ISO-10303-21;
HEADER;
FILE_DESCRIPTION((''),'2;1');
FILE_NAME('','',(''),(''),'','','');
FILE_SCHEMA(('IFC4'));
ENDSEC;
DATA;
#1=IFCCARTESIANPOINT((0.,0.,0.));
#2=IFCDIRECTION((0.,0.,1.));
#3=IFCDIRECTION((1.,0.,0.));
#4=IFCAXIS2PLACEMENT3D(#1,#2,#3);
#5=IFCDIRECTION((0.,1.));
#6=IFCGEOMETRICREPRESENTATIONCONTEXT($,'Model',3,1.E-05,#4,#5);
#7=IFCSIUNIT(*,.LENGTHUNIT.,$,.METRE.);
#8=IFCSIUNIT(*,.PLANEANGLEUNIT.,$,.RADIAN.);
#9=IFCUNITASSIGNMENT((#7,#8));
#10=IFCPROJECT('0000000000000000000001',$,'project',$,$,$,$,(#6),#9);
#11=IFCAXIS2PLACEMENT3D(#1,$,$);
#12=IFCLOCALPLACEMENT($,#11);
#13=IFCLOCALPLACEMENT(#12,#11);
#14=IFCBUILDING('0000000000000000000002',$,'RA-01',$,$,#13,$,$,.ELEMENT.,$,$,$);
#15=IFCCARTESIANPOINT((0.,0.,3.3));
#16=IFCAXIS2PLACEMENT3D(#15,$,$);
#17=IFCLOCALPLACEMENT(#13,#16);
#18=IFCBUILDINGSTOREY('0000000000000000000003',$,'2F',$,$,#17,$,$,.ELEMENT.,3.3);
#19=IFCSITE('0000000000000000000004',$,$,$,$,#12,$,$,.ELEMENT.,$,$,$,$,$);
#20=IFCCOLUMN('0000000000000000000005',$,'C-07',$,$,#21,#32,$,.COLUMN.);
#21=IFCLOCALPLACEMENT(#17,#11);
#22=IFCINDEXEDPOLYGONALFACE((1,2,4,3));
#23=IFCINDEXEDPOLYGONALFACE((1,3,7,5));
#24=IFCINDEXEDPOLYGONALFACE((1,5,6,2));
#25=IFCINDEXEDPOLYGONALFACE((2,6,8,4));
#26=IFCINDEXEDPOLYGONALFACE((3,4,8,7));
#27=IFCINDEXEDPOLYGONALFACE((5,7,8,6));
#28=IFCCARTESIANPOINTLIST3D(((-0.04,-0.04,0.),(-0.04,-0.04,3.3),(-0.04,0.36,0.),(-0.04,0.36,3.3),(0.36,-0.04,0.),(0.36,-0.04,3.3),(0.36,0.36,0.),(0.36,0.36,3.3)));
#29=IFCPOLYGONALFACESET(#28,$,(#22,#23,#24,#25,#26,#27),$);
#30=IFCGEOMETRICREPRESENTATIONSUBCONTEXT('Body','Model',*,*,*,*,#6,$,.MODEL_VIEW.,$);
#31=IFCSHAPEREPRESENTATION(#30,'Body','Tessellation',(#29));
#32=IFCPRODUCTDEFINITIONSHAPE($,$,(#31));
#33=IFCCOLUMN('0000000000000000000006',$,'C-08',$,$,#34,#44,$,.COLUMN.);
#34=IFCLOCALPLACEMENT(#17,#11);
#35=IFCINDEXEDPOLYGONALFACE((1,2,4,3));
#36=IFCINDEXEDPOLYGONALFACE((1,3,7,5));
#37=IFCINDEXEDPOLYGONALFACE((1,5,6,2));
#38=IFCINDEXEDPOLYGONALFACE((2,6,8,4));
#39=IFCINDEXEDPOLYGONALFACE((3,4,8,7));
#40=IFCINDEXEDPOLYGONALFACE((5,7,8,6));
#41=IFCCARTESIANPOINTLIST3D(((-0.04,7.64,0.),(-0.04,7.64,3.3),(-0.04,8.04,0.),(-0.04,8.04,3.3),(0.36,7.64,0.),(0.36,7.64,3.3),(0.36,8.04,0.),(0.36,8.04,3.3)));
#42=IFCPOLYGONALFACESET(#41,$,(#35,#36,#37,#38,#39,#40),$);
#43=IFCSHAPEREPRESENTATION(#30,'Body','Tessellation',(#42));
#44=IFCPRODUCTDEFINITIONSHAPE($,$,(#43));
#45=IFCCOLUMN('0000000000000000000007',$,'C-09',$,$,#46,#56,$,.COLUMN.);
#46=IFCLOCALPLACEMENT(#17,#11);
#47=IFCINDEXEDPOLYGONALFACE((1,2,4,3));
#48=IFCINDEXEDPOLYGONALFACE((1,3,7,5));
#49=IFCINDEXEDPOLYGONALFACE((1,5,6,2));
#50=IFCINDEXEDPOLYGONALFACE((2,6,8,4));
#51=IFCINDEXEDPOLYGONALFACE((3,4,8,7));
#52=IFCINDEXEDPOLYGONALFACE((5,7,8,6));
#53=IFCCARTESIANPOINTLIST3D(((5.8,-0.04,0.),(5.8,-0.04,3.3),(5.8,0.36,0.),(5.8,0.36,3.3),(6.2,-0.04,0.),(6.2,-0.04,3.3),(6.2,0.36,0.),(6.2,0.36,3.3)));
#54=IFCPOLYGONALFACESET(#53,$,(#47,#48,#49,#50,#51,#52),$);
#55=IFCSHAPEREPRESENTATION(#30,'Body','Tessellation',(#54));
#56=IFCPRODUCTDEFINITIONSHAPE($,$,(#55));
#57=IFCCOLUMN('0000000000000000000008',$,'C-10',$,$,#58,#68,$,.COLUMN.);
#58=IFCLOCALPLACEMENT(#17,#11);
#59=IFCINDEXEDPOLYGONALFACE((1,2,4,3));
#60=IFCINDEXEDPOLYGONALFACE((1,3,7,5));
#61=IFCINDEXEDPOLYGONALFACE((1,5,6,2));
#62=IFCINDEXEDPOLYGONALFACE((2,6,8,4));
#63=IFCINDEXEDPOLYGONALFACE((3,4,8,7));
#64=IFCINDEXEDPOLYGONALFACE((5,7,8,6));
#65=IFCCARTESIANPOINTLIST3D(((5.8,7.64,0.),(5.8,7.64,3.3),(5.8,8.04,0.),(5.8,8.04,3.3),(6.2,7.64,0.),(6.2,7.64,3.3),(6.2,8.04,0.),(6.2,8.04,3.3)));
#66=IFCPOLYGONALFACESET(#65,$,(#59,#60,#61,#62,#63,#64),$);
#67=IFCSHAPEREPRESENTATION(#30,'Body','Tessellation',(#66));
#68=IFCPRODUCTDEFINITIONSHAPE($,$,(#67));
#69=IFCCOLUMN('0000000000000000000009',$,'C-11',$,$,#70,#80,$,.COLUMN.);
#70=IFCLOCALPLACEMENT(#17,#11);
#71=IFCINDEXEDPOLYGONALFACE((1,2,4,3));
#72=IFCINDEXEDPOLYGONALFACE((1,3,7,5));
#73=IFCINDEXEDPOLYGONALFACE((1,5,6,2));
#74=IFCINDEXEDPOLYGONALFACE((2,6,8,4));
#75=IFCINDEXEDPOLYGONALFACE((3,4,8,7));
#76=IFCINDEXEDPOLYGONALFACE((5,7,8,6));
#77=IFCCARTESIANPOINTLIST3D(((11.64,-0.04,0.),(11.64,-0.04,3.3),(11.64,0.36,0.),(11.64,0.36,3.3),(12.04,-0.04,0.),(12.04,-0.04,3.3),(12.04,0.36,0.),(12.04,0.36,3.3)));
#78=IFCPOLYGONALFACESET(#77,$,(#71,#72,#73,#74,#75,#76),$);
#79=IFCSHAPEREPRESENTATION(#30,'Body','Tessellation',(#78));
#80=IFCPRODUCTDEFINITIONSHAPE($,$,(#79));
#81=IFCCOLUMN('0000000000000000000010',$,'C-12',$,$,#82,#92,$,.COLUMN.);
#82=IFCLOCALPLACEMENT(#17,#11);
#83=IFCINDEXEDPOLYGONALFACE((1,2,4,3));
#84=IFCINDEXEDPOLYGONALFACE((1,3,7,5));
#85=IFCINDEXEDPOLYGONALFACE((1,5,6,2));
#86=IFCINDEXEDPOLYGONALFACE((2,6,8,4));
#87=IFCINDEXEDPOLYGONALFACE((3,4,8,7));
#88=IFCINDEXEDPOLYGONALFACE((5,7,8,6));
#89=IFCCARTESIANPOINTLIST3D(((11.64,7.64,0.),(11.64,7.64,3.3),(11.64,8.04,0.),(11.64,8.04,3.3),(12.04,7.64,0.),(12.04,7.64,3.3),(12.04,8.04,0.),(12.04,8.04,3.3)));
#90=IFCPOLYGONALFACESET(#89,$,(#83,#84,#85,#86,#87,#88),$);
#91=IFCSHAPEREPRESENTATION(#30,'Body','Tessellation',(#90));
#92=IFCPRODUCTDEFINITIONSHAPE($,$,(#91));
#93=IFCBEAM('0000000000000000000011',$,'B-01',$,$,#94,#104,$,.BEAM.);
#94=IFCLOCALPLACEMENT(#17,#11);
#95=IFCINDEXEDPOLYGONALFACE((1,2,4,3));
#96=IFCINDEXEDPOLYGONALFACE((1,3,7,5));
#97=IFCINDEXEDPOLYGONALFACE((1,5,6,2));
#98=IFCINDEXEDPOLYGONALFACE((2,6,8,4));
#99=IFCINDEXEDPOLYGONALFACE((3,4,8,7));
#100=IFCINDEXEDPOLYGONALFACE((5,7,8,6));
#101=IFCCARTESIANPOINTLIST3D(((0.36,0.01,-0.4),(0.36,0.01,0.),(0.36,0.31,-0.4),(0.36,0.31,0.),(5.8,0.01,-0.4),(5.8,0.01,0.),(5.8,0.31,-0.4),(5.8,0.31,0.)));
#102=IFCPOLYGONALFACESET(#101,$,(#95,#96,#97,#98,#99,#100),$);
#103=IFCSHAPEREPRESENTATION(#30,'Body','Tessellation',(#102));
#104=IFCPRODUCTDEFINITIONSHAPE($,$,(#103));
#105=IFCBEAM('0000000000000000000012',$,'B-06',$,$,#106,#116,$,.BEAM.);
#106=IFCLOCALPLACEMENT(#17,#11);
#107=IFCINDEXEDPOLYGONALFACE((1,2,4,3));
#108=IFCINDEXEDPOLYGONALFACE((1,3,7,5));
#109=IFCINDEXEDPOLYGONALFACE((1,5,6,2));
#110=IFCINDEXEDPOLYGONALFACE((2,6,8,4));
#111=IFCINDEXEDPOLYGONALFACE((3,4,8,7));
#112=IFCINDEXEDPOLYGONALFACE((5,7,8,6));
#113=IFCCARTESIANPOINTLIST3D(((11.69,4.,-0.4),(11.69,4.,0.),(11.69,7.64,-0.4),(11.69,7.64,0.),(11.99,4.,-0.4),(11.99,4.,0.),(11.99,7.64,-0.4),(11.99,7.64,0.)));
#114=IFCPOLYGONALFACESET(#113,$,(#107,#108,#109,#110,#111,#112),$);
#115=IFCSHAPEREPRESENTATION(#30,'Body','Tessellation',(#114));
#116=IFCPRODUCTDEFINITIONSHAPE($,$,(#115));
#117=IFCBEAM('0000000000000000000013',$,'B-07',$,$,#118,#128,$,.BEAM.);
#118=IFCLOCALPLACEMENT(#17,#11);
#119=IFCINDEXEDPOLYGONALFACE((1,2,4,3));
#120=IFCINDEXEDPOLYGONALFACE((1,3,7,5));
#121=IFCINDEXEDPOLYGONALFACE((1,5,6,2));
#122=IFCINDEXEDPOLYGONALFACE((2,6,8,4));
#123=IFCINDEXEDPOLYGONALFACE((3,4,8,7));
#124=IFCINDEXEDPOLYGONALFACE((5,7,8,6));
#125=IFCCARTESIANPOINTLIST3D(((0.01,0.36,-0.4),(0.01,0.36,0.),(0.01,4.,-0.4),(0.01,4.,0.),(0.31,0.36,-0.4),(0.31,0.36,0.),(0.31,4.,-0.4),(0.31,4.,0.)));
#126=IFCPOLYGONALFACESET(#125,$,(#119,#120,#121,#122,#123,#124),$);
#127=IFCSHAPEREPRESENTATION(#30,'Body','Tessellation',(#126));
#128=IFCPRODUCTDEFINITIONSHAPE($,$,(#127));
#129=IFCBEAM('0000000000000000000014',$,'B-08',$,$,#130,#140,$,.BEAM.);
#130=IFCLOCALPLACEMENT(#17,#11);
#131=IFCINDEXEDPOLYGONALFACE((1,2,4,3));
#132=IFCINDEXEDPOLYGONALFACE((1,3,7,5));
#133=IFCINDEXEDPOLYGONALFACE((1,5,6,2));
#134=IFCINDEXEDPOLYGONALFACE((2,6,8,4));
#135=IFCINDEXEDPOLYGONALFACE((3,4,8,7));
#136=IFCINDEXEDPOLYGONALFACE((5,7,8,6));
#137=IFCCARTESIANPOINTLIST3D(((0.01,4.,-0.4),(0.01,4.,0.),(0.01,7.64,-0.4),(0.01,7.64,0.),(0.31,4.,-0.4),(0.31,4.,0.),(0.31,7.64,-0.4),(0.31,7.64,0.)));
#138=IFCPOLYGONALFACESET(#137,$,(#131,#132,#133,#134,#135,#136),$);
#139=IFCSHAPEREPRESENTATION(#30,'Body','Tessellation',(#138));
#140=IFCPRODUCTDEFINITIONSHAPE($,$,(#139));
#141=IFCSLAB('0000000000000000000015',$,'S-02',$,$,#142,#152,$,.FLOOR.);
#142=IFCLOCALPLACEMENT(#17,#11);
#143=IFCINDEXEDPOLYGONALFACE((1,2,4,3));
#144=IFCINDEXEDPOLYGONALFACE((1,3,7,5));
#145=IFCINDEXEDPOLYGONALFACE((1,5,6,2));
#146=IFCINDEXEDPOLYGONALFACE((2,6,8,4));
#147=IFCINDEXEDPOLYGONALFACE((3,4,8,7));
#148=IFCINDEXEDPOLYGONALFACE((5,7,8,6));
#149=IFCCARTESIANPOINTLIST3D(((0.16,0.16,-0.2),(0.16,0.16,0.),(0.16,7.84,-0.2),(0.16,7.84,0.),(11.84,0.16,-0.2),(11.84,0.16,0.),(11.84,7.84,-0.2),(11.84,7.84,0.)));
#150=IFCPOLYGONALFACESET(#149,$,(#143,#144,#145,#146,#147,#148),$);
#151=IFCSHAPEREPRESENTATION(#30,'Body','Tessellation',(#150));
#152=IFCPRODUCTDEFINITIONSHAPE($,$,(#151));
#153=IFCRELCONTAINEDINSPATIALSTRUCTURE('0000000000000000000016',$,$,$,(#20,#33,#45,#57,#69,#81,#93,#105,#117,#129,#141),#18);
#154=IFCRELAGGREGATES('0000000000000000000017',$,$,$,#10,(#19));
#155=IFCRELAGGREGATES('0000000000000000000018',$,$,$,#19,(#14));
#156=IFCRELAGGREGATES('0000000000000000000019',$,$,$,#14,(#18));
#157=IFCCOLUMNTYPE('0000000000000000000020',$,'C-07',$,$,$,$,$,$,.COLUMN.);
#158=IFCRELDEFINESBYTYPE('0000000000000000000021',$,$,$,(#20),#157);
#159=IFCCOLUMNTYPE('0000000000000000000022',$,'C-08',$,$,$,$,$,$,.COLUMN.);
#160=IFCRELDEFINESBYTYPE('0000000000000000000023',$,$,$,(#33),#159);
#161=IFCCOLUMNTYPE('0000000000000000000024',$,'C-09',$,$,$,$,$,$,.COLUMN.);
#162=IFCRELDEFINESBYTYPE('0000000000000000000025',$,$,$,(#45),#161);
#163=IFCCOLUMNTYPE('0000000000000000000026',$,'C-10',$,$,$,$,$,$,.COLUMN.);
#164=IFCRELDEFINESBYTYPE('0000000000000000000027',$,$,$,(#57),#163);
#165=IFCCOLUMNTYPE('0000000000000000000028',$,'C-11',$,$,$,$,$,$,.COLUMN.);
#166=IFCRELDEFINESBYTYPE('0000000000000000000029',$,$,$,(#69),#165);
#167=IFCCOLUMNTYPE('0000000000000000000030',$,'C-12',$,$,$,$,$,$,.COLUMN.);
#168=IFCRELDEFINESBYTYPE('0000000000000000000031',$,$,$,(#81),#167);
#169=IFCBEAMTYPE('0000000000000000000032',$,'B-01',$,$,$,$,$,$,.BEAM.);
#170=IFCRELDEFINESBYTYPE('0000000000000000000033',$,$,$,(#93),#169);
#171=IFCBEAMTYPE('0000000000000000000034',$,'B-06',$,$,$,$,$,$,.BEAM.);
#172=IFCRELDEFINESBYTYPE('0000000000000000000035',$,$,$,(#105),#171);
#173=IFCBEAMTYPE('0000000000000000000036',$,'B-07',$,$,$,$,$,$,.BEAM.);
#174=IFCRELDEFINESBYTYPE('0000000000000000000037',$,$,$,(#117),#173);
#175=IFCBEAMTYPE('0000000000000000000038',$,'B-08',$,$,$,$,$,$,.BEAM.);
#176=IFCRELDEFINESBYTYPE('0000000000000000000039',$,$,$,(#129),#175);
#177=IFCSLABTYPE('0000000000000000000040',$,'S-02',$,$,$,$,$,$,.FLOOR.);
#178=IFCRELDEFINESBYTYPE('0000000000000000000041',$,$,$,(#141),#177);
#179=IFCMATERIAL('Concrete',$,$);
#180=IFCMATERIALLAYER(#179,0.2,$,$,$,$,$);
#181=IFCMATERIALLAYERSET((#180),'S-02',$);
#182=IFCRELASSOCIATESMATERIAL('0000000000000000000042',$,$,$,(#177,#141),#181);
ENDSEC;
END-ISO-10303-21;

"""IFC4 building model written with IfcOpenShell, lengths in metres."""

from ifc_helpers import new_model, si_unit, direction, frame, frame_2d, origin, origin_with_axes, origin_2d, place, context, subcontext, project, spatial, polyline, rectangle, outline, extrude, material, layer, layer_set, layer_usage, type_object, element, save


model = new_model("IFC4")

# Units and contexts
model_context = context("Model", 3, precision=1e-05, world=origin_with_axes(), true_north=direction((0.0, 1.0)))
body_context = subcontext(model_context, "Body", "Model", "MODEL_VIEW")
ifc_project = project(units=[si_unit("LENGTHUNIT", "METRE"), si_unit("PLANEANGLEUNIT", "RADIAN")], contexts=[model_context])

# Site, building, storey
site_placement = place(None, origin())
site = spatial("IfcSite", under=ifc_project, at=site_placement, CompositionType="ELEMENT")
building_placement = place(site_placement, origin())
building = spatial("IfcBuilding", under=site, at=building_placement, Name="RA-01", CompositionType="ELEMENT")
storey_placement = place(building_placement, frame((0.0, 0.0, 3.3)))
storey = spatial("IfcBuildingStorey", under=building, at=storey_placement, Name="2F", CompositionType="ELEMENT", Elevation=3.3)

# Columns
column_type_1 = type_object("IfcColumnType", Name="C-07", PredefinedType="COLUMN")
column_1_placement = place(storey_placement, origin())
element("IfcColumn", 1, at=column_1_placement, inside=storey, type_object=column_type_1, Name="C-07", PredefinedType="COLUMN", context=body_context, shape_type="SweptSolid", body=[
    extrude(rectangle(XDim=0.4, YDim=0.4, at=origin_2d()), frame((0.16, 0.16, 0.0)), (0.0, 0.0, 1.0), 3.3),
])
column_type_2 = type_object("IfcColumnType", Name="C-08", PredefinedType="COLUMN")
column_2_placement = place(storey_placement, origin())
element("IfcColumn", 2, at=column_2_placement, inside=storey, type_object=column_type_2, Name="C-08", PredefinedType="COLUMN", context=body_context, shape_type="SweptSolid", body=[
    extrude(rectangle(XDim=0.4, YDim=0.4, at=origin_2d()), frame((0.16, 7.84, 0.0)), (0.0, 0.0, 1.0), 3.3),
])
column_type_3 = type_object("IfcColumnType", Name="C-09", PredefinedType="COLUMN")
column_3_placement = place(storey_placement, origin())
element("IfcColumn", 3, at=column_3_placement, inside=storey, type_object=column_type_3, Name="C-09", PredefinedType="COLUMN", context=body_context, shape_type="SweptSolid", body=[
    extrude(rectangle(XDim=0.4, YDim=0.4, at=origin_2d()), frame((6.0, 0.16, 0.0)), (0.0, 0.0, 1.0), 3.3),
])
column_type_4 = type_object("IfcColumnType", Name="C-10", PredefinedType="COLUMN")
column_4_placement = place(storey_placement, origin())
element("IfcColumn", 4, at=column_4_placement, inside=storey, type_object=column_type_4, Name="C-10", PredefinedType="COLUMN", context=body_context, shape_type="SweptSolid", body=[
    extrude(rectangle(XDim=0.4, YDim=0.4, at=origin_2d()), frame((6.0, 7.84, 0.0)), (0.0, 0.0, 1.0), 3.3),
])
column_type_5 = type_object("IfcColumnType", Name="C-11", PredefinedType="COLUMN")
column_5_placement = place(storey_placement, origin())
element("IfcColumn", 5, at=column_5_placement, inside=storey, type_object=column_type_5, Name="C-11", PredefinedType="COLUMN", context=body_context, shape_type="SweptSolid", body=[
    extrude(rectangle(XDim=0.4, YDim=0.4, at=origin_2d()), frame((11.84, 0.16, 0.0)), (0.0, 0.0, 1.0), 3.3),
])
column_type_6 = type_object("IfcColumnType", Name="C-12", PredefinedType="COLUMN")
column_6_placement = place(storey_placement, origin())
element("IfcColumn", 6, at=column_6_placement, inside=storey, type_object=column_type_6, Name="C-12", PredefinedType="COLUMN", context=body_context, shape_type="SweptSolid", body=[
    extrude(rectangle(XDim=0.4, YDim=0.4, at=origin_2d()), frame((11.84, 7.84, 0.0)), (0.0, 0.0, 1.0), 3.3),
])

# Beams
beam_type_1 = type_object("IfcBeamType", Name="B-01", PredefinedType="BEAM")
beam_1_placement = place(storey_placement, origin())
element("IfcBeam", 7, at=beam_1_placement, inside=storey, type_object=beam_type_1, Name="B-01", PredefinedType="BEAM", context=body_context, shape_type="SweptSolid", body=[
    extrude(rectangle(XDim=5.44, YDim=0.3, at=frame_2d((2.92, 0.0))), frame((0.16, 0.16, -0.4), z_axis=(0.0, 0.0, 1.0), x_axis=(1.0, 0.0, 0.0)), (0.0, 0.0, 1.0), 0.4),
])
beam_type_2 = type_object("IfcBeamType", Name="B-06", PredefinedType="BEAM")
beam_2_placement = place(storey_placement, origin())
element("IfcBeam", 8, at=beam_2_placement, inside=storey, type_object=beam_type_2, Name="B-06", PredefinedType="BEAM", context=body_context, shape_type="SweptSolid", body=[
    extrude(rectangle(XDim=3.64, YDim=0.3, at=frame_2d((1.82, 0.0))), frame((11.84, 4.0, -0.4), z_axis=(0.0, 0.0, 1.0), x_axis=(0.0, 1.0, 0.0)), (0.0, 0.0, 1.0), 0.4),
])
beam_type_3 = type_object("IfcBeamType", Name="B-07", PredefinedType="BEAM")
beam_3_placement = place(storey_placement, origin())
element("IfcBeam", 9, at=beam_3_placement, inside=storey, type_object=beam_type_3, Name="B-07", PredefinedType="BEAM", context=body_context, shape_type="SweptSolid", body=[
    extrude(rectangle(XDim=3.64, YDim=0.3, at=frame_2d((2.02, 0.0))), frame((0.16, 0.16, -0.4), z_axis=(0.0, 0.0, 1.0), x_axis=(0.0, 1.0, 0.0)), (0.0, 0.0, 1.0), 0.4),
])
beam_type_4 = type_object("IfcBeamType", Name="B-08", PredefinedType="BEAM")
beam_4_placement = place(storey_placement, origin())
element("IfcBeam", 10, at=beam_4_placement, inside=storey, type_object=beam_type_4, Name="B-08", PredefinedType="BEAM", context=body_context, shape_type="SweptSolid", body=[
    extrude(rectangle(XDim=3.64, YDim=0.3, at=frame_2d((1.82, 0.0))), frame((0.16, 4.0, -0.4), z_axis=(0.0, 0.0, 1.0), x_axis=(0.0, 1.0, 0.0)), (0.0, 0.0, 1.0), 0.4),
])

# Slab
ifc_material_1 = material(Name="Concrete")
ifc_layer_1 = layer(ifc_material_1, 0.2)
ifc_layer_set_1 = layer_set([ifc_layer_1], Name="S-02")
ifc_layer_usage_1 = layer_usage(ifc_layer_set_1, "AXIS3", "NEGATIVE", 0.2)
slab_type = type_object("IfcSlabType", Name="S-02", PredefinedType="FLOOR", material=ifc_layer_set_1)
slab_placement = place(storey_placement, frame((0.0, 0.0, -0.2)))
element("IfcSlab", 11, at=slab_placement, inside=storey, type_object=slab_type, material=ifc_layer_usage_1, Name="S-02", PredefinedType="FLOOR", context=body_context, shape_type="SweptSolid", body=[
    extrude(outline(polyline([(0.16, 0.16), (11.84, 0.16), (11.84, 7.84), (0.16, 7.84), (0.16, 0.16)])), origin(), (0.0, 0.0, 1.0), 0.2),
])

save(model, "model.ifc")
